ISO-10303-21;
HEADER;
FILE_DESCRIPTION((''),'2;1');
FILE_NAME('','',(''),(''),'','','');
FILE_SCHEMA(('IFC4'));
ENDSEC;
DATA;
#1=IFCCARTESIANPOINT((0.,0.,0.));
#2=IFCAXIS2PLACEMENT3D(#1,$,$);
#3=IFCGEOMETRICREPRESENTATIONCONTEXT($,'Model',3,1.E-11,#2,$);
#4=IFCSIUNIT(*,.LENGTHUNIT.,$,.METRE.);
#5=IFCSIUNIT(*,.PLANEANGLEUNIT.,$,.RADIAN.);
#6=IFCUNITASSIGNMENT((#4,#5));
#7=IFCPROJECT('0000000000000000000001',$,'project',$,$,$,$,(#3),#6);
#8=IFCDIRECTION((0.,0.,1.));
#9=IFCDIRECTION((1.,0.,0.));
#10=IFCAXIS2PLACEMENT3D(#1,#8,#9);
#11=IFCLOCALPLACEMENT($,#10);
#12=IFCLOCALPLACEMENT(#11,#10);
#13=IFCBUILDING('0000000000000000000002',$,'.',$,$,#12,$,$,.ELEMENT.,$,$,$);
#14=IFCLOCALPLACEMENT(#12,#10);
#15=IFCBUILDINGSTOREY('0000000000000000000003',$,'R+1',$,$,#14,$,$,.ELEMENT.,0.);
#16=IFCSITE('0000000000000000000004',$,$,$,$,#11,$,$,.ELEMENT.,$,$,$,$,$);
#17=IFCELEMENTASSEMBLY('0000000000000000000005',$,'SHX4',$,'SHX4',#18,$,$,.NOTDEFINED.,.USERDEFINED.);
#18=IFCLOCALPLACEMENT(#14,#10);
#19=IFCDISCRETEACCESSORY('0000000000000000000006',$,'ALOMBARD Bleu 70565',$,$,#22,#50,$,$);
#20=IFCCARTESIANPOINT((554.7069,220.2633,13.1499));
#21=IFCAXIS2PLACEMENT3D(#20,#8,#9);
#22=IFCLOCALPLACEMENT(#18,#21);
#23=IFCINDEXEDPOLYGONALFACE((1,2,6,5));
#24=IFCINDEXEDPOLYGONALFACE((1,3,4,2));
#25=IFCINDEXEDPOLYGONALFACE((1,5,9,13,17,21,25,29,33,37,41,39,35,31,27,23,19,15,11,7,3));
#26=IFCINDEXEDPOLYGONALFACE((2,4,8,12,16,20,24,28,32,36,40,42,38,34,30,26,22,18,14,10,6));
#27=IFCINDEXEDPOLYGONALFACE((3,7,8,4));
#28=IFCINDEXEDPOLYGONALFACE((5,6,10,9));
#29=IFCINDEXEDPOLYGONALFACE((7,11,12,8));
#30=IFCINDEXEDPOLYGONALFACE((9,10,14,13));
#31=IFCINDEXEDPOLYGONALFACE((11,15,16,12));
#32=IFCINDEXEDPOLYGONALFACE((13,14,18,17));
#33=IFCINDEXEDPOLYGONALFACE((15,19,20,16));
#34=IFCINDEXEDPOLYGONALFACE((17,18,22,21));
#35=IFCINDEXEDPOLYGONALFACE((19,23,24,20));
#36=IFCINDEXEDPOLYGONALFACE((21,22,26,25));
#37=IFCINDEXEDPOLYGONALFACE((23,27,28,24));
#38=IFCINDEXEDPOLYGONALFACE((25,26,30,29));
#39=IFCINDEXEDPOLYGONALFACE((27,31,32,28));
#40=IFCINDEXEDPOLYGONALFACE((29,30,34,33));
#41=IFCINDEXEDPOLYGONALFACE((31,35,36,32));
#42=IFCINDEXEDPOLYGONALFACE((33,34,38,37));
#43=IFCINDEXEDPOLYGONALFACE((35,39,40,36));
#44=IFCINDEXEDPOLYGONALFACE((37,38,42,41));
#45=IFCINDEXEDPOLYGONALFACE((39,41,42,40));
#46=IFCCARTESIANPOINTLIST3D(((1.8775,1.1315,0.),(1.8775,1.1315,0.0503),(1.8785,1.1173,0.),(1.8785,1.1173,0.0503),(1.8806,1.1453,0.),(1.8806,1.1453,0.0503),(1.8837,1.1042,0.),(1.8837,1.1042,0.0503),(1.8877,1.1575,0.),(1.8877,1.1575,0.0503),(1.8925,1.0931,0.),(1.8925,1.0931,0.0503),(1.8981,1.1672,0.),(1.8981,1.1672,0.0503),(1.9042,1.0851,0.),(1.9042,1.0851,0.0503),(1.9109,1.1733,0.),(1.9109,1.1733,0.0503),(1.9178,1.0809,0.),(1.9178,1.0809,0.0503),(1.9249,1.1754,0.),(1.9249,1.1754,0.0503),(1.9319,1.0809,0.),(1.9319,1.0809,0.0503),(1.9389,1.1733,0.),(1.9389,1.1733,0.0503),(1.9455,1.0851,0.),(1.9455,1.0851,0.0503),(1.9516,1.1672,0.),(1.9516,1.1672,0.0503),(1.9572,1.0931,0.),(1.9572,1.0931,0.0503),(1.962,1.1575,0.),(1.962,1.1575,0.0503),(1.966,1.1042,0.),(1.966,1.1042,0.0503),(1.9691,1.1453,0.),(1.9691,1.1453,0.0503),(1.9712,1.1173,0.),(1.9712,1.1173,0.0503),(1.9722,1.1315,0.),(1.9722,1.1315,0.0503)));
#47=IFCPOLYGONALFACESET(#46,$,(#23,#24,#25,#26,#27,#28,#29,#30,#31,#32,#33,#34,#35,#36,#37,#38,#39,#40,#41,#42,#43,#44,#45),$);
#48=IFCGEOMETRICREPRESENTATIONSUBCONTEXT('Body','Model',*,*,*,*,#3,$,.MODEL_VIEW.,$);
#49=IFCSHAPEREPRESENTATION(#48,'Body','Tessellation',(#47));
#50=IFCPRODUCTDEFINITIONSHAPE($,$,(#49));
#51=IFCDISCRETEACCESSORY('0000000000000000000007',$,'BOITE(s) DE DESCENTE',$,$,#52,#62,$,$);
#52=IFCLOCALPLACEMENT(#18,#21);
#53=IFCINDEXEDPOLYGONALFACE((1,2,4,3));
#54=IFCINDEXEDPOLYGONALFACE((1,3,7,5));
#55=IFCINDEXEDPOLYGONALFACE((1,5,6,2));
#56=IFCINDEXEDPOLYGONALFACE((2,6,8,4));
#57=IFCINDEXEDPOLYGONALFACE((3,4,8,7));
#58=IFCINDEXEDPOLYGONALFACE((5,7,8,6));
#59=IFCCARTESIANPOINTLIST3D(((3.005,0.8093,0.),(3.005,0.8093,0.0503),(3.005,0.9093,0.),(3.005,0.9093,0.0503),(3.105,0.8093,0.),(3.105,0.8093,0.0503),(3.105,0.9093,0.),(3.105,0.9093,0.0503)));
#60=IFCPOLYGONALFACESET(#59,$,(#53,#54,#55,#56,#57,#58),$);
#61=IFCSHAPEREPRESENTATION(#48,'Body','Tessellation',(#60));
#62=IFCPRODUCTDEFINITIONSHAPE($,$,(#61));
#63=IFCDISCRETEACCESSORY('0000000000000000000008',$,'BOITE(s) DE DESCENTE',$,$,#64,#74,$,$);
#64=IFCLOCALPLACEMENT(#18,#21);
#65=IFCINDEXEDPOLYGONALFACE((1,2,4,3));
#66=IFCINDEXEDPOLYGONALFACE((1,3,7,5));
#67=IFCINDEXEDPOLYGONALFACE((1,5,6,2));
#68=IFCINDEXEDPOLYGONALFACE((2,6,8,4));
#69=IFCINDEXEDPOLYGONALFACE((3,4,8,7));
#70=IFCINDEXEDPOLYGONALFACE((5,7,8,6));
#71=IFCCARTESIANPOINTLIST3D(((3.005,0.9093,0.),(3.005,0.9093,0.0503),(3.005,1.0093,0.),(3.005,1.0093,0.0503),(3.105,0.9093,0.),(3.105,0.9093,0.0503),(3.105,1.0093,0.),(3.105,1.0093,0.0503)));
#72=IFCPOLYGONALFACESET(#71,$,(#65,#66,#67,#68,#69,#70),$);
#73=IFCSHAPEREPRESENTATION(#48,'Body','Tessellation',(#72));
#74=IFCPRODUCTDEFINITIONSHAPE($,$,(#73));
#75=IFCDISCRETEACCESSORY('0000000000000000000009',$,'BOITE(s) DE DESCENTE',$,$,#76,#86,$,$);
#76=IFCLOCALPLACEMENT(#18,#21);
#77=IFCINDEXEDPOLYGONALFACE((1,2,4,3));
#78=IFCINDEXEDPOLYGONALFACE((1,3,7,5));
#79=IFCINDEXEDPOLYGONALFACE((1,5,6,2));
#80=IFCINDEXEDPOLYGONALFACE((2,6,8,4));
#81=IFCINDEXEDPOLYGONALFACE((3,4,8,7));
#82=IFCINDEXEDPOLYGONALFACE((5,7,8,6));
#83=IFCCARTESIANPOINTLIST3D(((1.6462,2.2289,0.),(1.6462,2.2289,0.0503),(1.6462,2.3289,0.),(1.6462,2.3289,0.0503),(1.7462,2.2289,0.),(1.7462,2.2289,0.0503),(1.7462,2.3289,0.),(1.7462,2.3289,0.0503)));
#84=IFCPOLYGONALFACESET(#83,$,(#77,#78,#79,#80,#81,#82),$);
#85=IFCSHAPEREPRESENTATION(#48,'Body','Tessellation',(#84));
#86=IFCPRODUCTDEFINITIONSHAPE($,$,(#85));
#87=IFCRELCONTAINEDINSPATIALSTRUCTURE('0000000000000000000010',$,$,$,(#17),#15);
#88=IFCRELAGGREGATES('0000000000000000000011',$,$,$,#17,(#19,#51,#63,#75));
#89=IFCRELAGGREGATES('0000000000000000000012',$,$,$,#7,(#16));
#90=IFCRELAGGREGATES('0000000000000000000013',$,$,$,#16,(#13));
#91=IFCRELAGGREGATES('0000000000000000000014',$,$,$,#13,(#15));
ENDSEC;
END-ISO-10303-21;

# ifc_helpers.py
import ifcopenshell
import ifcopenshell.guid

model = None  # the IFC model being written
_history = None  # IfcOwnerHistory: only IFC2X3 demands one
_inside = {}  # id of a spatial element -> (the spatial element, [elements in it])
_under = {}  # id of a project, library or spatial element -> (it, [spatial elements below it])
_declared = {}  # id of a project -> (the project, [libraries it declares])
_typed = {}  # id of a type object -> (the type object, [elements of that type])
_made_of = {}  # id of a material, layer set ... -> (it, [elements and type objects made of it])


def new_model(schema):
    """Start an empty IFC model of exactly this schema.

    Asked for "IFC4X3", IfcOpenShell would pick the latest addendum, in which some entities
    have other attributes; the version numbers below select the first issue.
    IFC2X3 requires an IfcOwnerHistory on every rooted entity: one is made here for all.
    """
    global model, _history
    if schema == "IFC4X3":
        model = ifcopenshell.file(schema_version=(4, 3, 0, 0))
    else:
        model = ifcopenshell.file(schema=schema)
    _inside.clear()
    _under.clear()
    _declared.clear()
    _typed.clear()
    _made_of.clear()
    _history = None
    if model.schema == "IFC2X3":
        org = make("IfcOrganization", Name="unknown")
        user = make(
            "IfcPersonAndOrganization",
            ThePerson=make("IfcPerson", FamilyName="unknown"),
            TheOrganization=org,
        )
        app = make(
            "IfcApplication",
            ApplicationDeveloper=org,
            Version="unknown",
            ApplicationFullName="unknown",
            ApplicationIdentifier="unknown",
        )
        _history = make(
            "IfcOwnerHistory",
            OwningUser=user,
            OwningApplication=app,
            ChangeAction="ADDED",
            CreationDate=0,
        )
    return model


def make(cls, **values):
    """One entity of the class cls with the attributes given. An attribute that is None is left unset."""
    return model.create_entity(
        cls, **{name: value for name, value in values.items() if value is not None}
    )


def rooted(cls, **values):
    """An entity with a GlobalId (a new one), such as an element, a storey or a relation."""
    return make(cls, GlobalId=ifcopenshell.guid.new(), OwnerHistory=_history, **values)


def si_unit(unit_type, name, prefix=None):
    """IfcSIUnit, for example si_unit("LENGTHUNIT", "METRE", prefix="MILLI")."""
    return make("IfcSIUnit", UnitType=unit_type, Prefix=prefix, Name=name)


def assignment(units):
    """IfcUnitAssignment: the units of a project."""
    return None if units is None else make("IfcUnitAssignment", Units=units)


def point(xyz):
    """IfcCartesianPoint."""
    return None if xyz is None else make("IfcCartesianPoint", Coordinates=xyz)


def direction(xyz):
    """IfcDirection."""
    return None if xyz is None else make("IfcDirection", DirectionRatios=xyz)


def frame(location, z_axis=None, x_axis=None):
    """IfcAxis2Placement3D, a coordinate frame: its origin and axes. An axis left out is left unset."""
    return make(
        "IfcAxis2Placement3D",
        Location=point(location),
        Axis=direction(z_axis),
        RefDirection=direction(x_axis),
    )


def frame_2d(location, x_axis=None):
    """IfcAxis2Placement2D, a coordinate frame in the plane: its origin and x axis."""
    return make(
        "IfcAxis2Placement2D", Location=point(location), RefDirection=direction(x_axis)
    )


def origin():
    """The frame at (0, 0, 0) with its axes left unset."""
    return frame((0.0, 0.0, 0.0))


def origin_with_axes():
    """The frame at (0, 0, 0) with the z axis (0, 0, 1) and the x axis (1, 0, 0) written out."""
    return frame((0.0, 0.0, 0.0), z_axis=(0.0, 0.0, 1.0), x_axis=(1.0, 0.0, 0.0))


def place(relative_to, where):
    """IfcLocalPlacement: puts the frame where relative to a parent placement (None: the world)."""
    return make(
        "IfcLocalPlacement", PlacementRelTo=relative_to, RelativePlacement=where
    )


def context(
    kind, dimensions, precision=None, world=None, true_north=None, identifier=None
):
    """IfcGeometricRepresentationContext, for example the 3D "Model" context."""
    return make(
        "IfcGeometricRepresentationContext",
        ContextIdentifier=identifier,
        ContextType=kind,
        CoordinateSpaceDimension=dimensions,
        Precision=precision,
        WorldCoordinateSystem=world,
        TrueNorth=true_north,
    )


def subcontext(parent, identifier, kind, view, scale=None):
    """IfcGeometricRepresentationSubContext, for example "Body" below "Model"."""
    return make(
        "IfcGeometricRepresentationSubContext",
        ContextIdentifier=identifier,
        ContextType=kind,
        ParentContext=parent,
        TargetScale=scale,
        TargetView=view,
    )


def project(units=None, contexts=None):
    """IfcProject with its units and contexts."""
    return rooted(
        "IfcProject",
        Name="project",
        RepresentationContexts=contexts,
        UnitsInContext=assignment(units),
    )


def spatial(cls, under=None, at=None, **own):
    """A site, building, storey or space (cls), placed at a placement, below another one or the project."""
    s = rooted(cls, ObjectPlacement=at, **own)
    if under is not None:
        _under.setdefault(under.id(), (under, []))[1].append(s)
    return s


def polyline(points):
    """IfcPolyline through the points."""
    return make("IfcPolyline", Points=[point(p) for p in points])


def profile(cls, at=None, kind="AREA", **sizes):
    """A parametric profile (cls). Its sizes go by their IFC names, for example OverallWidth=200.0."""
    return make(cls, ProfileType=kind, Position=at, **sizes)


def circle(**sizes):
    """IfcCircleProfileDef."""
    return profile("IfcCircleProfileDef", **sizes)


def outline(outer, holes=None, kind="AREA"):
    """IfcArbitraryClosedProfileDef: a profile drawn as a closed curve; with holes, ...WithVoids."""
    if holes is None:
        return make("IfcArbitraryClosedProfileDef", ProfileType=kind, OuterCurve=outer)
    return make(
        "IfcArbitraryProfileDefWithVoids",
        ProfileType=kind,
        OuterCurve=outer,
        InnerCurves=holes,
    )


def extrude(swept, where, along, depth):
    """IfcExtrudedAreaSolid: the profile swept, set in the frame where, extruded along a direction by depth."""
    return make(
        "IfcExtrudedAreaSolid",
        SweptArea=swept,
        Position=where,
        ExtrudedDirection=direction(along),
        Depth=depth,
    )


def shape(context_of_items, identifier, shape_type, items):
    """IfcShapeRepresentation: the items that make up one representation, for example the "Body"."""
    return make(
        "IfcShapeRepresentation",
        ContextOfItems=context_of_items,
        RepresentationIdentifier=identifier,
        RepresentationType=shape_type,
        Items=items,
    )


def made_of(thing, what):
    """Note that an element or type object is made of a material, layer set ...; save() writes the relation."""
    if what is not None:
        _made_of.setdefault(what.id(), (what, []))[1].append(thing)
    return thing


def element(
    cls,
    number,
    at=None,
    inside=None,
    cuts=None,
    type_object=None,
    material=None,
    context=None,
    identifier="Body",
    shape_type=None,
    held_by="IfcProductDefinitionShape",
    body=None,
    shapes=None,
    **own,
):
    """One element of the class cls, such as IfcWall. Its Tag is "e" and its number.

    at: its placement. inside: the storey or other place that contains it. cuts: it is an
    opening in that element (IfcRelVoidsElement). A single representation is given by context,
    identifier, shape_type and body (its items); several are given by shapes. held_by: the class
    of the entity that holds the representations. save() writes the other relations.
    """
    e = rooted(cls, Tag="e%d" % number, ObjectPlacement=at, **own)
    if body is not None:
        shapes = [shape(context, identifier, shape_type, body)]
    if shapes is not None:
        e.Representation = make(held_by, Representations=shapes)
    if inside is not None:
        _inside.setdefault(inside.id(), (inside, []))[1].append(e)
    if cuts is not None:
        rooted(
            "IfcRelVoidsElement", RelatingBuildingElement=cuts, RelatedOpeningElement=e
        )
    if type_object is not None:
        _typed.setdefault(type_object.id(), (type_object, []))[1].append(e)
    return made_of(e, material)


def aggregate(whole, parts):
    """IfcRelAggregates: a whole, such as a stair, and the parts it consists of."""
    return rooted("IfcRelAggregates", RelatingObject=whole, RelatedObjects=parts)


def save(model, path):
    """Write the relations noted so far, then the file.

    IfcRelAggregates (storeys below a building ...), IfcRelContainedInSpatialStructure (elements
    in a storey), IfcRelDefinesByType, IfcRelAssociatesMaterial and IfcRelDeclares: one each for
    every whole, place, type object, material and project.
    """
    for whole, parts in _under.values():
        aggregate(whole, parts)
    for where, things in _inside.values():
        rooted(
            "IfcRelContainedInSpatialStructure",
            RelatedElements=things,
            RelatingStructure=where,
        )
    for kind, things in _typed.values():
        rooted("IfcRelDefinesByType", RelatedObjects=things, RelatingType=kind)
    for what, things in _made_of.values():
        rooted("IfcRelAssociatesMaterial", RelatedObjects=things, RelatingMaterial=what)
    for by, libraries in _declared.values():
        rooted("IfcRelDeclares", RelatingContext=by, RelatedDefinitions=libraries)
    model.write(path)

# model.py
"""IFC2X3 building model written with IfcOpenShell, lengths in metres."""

from ifc_helpers import new_model, si_unit, frame, frame_2d, origin, origin_with_axes, place, context, subcontext, project, spatial, polyline, circle, outline, extrude, element, aggregate, save


model = new_model("IFC2X3")

# Units and contexts
model_context = context("Model", 3, precision=1e-11, world=origin())
body_context = subcontext(model_context, "Body", "Model", "MODEL_VIEW")
ifc_project = project(units=[si_unit("LENGTHUNIT", "METRE"), si_unit("PLANEANGLEUNIT", "RADIAN")], contexts=[model_context])

# Site, building, storey
site_placement = place(None, origin_with_axes())
site = spatial("IfcSite", under=ifc_project, at=site_placement, CompositionType="ELEMENT")
building_placement = place(site_placement, origin_with_axes())
building = spatial("IfcBuilding", under=site, at=building_placement, Name=".", CompositionType="ELEMENT")
storey_placement = place(building_placement, origin_with_axes())
storey = spatial("IfcBuildingStorey", under=building, at=storey_placement, Name="R+1", CompositionType="ELEMENT", Elevation=0.0)

# Element assembly, discrete accessories
assembly_1_placement = place(storey_placement, origin_with_axes())
assembly_1 = element("IfcElementAssembly", 1, at=assembly_1_placement, inside=storey, Name="SHX4", ObjectType="SHX4", AssemblyPlace="NOTDEFINED", PredefinedType="USERDEFINED")
discrete_accessory_1_placement = place(assembly_1_placement, frame((554.7069, 220.2633, 13.1499), z_axis=(0.0, 0.0, 1.0), x_axis=(1.0, 0.0, 0.0)))
discrete_accessory_1 = element("IfcDiscreteAccessory", 2, at=discrete_accessory_1_placement, Name="ALOMBARD Bleu 70565", context=body_context, shape_type="SweptSolid", body=[
    extrude(circle(Radius=0.0475, at=frame_2d((1.1279, -1.9249), x_axis=(1.0, 0.0))), frame((0.0, 0.0, 0.0), z_axis=(0.0, 0.0, 1.0), x_axis=(0.0, 1.0, 0.0)), (0.0, 0.0, 1.0), 0.0503),
])
discrete_accessory_2_placement = place(assembly_1_placement, frame((554.7069, 220.2633, 13.1499), z_axis=(0.0, 0.0, 1.0), x_axis=(1.0, 0.0, 0.0)))
discrete_accessory_2 = element("IfcDiscreteAccessory", 3, at=discrete_accessory_2_placement, Name="BOITE(s) DE DESCENTE", context=body_context, shape_type="SweptSolid", body=[
    extrude(outline(polyline([(0.8093, -3.005), (0.8093, -3.105), (0.9093, -3.105), (0.9093, -3.005), (0.8093, -3.005)])), frame((0.0, 0.0, 0.0), z_axis=(0.0, 0.0, 1.0), x_axis=(0.0, 1.0, 0.0)), (0.0, 0.0, 1.0), 0.0503),
])
discrete_accessory_3_placement = place(assembly_1_placement, frame((554.7069, 220.2633, 13.1499), z_axis=(0.0, 0.0, 1.0), x_axis=(1.0, 0.0, 0.0)))
discrete_accessory_3 = element("IfcDiscreteAccessory", 4, at=discrete_accessory_3_placement, Name="BOITE(s) DE DESCENTE", context=body_context, shape_type="SweptSolid", body=[
    extrude(outline(polyline([(0.9093, -3.005), (0.9093, -3.105), (1.0093, -3.105), (1.0093, -3.005), (0.9093, -3.005)])), frame((0.0, 0.0, 0.0), z_axis=(0.0, 0.0, 1.0), x_axis=(0.0, 1.0, 0.0)), (0.0, 0.0, 1.0), 0.0503),
])
discrete_accessory_4_placement = place(assembly_1_placement, frame((554.7069, 220.2633, 13.1499), z_axis=(0.0, 0.0, 1.0), x_axis=(1.0, 0.0, 0.0)))
discrete_accessory_4 = element("IfcDiscreteAccessory", 5, at=discrete_accessory_4_placement, Name="BOITE(s) DE DESCENTE", context=body_context, shape_type="SweptSolid", body=[
    extrude(outline(polyline([(2.2289, -1.6462), (2.2289, -1.7462), (2.3289, -1.7462), (2.3289, -1.6462), (2.2289, -1.6462)])), frame((0.0, 0.0, 0.0), z_axis=(0.0, 0.0, 1.0), x_axis=(0.0, 1.0, 0.0)), (0.0, 0.0, 1.0), 0.0503),
])
aggregate(assembly_1, [discrete_accessory_1, discrete_accessory_2, discrete_accessory_3, discrete_accessory_4])

save(model, "model.ifc")
